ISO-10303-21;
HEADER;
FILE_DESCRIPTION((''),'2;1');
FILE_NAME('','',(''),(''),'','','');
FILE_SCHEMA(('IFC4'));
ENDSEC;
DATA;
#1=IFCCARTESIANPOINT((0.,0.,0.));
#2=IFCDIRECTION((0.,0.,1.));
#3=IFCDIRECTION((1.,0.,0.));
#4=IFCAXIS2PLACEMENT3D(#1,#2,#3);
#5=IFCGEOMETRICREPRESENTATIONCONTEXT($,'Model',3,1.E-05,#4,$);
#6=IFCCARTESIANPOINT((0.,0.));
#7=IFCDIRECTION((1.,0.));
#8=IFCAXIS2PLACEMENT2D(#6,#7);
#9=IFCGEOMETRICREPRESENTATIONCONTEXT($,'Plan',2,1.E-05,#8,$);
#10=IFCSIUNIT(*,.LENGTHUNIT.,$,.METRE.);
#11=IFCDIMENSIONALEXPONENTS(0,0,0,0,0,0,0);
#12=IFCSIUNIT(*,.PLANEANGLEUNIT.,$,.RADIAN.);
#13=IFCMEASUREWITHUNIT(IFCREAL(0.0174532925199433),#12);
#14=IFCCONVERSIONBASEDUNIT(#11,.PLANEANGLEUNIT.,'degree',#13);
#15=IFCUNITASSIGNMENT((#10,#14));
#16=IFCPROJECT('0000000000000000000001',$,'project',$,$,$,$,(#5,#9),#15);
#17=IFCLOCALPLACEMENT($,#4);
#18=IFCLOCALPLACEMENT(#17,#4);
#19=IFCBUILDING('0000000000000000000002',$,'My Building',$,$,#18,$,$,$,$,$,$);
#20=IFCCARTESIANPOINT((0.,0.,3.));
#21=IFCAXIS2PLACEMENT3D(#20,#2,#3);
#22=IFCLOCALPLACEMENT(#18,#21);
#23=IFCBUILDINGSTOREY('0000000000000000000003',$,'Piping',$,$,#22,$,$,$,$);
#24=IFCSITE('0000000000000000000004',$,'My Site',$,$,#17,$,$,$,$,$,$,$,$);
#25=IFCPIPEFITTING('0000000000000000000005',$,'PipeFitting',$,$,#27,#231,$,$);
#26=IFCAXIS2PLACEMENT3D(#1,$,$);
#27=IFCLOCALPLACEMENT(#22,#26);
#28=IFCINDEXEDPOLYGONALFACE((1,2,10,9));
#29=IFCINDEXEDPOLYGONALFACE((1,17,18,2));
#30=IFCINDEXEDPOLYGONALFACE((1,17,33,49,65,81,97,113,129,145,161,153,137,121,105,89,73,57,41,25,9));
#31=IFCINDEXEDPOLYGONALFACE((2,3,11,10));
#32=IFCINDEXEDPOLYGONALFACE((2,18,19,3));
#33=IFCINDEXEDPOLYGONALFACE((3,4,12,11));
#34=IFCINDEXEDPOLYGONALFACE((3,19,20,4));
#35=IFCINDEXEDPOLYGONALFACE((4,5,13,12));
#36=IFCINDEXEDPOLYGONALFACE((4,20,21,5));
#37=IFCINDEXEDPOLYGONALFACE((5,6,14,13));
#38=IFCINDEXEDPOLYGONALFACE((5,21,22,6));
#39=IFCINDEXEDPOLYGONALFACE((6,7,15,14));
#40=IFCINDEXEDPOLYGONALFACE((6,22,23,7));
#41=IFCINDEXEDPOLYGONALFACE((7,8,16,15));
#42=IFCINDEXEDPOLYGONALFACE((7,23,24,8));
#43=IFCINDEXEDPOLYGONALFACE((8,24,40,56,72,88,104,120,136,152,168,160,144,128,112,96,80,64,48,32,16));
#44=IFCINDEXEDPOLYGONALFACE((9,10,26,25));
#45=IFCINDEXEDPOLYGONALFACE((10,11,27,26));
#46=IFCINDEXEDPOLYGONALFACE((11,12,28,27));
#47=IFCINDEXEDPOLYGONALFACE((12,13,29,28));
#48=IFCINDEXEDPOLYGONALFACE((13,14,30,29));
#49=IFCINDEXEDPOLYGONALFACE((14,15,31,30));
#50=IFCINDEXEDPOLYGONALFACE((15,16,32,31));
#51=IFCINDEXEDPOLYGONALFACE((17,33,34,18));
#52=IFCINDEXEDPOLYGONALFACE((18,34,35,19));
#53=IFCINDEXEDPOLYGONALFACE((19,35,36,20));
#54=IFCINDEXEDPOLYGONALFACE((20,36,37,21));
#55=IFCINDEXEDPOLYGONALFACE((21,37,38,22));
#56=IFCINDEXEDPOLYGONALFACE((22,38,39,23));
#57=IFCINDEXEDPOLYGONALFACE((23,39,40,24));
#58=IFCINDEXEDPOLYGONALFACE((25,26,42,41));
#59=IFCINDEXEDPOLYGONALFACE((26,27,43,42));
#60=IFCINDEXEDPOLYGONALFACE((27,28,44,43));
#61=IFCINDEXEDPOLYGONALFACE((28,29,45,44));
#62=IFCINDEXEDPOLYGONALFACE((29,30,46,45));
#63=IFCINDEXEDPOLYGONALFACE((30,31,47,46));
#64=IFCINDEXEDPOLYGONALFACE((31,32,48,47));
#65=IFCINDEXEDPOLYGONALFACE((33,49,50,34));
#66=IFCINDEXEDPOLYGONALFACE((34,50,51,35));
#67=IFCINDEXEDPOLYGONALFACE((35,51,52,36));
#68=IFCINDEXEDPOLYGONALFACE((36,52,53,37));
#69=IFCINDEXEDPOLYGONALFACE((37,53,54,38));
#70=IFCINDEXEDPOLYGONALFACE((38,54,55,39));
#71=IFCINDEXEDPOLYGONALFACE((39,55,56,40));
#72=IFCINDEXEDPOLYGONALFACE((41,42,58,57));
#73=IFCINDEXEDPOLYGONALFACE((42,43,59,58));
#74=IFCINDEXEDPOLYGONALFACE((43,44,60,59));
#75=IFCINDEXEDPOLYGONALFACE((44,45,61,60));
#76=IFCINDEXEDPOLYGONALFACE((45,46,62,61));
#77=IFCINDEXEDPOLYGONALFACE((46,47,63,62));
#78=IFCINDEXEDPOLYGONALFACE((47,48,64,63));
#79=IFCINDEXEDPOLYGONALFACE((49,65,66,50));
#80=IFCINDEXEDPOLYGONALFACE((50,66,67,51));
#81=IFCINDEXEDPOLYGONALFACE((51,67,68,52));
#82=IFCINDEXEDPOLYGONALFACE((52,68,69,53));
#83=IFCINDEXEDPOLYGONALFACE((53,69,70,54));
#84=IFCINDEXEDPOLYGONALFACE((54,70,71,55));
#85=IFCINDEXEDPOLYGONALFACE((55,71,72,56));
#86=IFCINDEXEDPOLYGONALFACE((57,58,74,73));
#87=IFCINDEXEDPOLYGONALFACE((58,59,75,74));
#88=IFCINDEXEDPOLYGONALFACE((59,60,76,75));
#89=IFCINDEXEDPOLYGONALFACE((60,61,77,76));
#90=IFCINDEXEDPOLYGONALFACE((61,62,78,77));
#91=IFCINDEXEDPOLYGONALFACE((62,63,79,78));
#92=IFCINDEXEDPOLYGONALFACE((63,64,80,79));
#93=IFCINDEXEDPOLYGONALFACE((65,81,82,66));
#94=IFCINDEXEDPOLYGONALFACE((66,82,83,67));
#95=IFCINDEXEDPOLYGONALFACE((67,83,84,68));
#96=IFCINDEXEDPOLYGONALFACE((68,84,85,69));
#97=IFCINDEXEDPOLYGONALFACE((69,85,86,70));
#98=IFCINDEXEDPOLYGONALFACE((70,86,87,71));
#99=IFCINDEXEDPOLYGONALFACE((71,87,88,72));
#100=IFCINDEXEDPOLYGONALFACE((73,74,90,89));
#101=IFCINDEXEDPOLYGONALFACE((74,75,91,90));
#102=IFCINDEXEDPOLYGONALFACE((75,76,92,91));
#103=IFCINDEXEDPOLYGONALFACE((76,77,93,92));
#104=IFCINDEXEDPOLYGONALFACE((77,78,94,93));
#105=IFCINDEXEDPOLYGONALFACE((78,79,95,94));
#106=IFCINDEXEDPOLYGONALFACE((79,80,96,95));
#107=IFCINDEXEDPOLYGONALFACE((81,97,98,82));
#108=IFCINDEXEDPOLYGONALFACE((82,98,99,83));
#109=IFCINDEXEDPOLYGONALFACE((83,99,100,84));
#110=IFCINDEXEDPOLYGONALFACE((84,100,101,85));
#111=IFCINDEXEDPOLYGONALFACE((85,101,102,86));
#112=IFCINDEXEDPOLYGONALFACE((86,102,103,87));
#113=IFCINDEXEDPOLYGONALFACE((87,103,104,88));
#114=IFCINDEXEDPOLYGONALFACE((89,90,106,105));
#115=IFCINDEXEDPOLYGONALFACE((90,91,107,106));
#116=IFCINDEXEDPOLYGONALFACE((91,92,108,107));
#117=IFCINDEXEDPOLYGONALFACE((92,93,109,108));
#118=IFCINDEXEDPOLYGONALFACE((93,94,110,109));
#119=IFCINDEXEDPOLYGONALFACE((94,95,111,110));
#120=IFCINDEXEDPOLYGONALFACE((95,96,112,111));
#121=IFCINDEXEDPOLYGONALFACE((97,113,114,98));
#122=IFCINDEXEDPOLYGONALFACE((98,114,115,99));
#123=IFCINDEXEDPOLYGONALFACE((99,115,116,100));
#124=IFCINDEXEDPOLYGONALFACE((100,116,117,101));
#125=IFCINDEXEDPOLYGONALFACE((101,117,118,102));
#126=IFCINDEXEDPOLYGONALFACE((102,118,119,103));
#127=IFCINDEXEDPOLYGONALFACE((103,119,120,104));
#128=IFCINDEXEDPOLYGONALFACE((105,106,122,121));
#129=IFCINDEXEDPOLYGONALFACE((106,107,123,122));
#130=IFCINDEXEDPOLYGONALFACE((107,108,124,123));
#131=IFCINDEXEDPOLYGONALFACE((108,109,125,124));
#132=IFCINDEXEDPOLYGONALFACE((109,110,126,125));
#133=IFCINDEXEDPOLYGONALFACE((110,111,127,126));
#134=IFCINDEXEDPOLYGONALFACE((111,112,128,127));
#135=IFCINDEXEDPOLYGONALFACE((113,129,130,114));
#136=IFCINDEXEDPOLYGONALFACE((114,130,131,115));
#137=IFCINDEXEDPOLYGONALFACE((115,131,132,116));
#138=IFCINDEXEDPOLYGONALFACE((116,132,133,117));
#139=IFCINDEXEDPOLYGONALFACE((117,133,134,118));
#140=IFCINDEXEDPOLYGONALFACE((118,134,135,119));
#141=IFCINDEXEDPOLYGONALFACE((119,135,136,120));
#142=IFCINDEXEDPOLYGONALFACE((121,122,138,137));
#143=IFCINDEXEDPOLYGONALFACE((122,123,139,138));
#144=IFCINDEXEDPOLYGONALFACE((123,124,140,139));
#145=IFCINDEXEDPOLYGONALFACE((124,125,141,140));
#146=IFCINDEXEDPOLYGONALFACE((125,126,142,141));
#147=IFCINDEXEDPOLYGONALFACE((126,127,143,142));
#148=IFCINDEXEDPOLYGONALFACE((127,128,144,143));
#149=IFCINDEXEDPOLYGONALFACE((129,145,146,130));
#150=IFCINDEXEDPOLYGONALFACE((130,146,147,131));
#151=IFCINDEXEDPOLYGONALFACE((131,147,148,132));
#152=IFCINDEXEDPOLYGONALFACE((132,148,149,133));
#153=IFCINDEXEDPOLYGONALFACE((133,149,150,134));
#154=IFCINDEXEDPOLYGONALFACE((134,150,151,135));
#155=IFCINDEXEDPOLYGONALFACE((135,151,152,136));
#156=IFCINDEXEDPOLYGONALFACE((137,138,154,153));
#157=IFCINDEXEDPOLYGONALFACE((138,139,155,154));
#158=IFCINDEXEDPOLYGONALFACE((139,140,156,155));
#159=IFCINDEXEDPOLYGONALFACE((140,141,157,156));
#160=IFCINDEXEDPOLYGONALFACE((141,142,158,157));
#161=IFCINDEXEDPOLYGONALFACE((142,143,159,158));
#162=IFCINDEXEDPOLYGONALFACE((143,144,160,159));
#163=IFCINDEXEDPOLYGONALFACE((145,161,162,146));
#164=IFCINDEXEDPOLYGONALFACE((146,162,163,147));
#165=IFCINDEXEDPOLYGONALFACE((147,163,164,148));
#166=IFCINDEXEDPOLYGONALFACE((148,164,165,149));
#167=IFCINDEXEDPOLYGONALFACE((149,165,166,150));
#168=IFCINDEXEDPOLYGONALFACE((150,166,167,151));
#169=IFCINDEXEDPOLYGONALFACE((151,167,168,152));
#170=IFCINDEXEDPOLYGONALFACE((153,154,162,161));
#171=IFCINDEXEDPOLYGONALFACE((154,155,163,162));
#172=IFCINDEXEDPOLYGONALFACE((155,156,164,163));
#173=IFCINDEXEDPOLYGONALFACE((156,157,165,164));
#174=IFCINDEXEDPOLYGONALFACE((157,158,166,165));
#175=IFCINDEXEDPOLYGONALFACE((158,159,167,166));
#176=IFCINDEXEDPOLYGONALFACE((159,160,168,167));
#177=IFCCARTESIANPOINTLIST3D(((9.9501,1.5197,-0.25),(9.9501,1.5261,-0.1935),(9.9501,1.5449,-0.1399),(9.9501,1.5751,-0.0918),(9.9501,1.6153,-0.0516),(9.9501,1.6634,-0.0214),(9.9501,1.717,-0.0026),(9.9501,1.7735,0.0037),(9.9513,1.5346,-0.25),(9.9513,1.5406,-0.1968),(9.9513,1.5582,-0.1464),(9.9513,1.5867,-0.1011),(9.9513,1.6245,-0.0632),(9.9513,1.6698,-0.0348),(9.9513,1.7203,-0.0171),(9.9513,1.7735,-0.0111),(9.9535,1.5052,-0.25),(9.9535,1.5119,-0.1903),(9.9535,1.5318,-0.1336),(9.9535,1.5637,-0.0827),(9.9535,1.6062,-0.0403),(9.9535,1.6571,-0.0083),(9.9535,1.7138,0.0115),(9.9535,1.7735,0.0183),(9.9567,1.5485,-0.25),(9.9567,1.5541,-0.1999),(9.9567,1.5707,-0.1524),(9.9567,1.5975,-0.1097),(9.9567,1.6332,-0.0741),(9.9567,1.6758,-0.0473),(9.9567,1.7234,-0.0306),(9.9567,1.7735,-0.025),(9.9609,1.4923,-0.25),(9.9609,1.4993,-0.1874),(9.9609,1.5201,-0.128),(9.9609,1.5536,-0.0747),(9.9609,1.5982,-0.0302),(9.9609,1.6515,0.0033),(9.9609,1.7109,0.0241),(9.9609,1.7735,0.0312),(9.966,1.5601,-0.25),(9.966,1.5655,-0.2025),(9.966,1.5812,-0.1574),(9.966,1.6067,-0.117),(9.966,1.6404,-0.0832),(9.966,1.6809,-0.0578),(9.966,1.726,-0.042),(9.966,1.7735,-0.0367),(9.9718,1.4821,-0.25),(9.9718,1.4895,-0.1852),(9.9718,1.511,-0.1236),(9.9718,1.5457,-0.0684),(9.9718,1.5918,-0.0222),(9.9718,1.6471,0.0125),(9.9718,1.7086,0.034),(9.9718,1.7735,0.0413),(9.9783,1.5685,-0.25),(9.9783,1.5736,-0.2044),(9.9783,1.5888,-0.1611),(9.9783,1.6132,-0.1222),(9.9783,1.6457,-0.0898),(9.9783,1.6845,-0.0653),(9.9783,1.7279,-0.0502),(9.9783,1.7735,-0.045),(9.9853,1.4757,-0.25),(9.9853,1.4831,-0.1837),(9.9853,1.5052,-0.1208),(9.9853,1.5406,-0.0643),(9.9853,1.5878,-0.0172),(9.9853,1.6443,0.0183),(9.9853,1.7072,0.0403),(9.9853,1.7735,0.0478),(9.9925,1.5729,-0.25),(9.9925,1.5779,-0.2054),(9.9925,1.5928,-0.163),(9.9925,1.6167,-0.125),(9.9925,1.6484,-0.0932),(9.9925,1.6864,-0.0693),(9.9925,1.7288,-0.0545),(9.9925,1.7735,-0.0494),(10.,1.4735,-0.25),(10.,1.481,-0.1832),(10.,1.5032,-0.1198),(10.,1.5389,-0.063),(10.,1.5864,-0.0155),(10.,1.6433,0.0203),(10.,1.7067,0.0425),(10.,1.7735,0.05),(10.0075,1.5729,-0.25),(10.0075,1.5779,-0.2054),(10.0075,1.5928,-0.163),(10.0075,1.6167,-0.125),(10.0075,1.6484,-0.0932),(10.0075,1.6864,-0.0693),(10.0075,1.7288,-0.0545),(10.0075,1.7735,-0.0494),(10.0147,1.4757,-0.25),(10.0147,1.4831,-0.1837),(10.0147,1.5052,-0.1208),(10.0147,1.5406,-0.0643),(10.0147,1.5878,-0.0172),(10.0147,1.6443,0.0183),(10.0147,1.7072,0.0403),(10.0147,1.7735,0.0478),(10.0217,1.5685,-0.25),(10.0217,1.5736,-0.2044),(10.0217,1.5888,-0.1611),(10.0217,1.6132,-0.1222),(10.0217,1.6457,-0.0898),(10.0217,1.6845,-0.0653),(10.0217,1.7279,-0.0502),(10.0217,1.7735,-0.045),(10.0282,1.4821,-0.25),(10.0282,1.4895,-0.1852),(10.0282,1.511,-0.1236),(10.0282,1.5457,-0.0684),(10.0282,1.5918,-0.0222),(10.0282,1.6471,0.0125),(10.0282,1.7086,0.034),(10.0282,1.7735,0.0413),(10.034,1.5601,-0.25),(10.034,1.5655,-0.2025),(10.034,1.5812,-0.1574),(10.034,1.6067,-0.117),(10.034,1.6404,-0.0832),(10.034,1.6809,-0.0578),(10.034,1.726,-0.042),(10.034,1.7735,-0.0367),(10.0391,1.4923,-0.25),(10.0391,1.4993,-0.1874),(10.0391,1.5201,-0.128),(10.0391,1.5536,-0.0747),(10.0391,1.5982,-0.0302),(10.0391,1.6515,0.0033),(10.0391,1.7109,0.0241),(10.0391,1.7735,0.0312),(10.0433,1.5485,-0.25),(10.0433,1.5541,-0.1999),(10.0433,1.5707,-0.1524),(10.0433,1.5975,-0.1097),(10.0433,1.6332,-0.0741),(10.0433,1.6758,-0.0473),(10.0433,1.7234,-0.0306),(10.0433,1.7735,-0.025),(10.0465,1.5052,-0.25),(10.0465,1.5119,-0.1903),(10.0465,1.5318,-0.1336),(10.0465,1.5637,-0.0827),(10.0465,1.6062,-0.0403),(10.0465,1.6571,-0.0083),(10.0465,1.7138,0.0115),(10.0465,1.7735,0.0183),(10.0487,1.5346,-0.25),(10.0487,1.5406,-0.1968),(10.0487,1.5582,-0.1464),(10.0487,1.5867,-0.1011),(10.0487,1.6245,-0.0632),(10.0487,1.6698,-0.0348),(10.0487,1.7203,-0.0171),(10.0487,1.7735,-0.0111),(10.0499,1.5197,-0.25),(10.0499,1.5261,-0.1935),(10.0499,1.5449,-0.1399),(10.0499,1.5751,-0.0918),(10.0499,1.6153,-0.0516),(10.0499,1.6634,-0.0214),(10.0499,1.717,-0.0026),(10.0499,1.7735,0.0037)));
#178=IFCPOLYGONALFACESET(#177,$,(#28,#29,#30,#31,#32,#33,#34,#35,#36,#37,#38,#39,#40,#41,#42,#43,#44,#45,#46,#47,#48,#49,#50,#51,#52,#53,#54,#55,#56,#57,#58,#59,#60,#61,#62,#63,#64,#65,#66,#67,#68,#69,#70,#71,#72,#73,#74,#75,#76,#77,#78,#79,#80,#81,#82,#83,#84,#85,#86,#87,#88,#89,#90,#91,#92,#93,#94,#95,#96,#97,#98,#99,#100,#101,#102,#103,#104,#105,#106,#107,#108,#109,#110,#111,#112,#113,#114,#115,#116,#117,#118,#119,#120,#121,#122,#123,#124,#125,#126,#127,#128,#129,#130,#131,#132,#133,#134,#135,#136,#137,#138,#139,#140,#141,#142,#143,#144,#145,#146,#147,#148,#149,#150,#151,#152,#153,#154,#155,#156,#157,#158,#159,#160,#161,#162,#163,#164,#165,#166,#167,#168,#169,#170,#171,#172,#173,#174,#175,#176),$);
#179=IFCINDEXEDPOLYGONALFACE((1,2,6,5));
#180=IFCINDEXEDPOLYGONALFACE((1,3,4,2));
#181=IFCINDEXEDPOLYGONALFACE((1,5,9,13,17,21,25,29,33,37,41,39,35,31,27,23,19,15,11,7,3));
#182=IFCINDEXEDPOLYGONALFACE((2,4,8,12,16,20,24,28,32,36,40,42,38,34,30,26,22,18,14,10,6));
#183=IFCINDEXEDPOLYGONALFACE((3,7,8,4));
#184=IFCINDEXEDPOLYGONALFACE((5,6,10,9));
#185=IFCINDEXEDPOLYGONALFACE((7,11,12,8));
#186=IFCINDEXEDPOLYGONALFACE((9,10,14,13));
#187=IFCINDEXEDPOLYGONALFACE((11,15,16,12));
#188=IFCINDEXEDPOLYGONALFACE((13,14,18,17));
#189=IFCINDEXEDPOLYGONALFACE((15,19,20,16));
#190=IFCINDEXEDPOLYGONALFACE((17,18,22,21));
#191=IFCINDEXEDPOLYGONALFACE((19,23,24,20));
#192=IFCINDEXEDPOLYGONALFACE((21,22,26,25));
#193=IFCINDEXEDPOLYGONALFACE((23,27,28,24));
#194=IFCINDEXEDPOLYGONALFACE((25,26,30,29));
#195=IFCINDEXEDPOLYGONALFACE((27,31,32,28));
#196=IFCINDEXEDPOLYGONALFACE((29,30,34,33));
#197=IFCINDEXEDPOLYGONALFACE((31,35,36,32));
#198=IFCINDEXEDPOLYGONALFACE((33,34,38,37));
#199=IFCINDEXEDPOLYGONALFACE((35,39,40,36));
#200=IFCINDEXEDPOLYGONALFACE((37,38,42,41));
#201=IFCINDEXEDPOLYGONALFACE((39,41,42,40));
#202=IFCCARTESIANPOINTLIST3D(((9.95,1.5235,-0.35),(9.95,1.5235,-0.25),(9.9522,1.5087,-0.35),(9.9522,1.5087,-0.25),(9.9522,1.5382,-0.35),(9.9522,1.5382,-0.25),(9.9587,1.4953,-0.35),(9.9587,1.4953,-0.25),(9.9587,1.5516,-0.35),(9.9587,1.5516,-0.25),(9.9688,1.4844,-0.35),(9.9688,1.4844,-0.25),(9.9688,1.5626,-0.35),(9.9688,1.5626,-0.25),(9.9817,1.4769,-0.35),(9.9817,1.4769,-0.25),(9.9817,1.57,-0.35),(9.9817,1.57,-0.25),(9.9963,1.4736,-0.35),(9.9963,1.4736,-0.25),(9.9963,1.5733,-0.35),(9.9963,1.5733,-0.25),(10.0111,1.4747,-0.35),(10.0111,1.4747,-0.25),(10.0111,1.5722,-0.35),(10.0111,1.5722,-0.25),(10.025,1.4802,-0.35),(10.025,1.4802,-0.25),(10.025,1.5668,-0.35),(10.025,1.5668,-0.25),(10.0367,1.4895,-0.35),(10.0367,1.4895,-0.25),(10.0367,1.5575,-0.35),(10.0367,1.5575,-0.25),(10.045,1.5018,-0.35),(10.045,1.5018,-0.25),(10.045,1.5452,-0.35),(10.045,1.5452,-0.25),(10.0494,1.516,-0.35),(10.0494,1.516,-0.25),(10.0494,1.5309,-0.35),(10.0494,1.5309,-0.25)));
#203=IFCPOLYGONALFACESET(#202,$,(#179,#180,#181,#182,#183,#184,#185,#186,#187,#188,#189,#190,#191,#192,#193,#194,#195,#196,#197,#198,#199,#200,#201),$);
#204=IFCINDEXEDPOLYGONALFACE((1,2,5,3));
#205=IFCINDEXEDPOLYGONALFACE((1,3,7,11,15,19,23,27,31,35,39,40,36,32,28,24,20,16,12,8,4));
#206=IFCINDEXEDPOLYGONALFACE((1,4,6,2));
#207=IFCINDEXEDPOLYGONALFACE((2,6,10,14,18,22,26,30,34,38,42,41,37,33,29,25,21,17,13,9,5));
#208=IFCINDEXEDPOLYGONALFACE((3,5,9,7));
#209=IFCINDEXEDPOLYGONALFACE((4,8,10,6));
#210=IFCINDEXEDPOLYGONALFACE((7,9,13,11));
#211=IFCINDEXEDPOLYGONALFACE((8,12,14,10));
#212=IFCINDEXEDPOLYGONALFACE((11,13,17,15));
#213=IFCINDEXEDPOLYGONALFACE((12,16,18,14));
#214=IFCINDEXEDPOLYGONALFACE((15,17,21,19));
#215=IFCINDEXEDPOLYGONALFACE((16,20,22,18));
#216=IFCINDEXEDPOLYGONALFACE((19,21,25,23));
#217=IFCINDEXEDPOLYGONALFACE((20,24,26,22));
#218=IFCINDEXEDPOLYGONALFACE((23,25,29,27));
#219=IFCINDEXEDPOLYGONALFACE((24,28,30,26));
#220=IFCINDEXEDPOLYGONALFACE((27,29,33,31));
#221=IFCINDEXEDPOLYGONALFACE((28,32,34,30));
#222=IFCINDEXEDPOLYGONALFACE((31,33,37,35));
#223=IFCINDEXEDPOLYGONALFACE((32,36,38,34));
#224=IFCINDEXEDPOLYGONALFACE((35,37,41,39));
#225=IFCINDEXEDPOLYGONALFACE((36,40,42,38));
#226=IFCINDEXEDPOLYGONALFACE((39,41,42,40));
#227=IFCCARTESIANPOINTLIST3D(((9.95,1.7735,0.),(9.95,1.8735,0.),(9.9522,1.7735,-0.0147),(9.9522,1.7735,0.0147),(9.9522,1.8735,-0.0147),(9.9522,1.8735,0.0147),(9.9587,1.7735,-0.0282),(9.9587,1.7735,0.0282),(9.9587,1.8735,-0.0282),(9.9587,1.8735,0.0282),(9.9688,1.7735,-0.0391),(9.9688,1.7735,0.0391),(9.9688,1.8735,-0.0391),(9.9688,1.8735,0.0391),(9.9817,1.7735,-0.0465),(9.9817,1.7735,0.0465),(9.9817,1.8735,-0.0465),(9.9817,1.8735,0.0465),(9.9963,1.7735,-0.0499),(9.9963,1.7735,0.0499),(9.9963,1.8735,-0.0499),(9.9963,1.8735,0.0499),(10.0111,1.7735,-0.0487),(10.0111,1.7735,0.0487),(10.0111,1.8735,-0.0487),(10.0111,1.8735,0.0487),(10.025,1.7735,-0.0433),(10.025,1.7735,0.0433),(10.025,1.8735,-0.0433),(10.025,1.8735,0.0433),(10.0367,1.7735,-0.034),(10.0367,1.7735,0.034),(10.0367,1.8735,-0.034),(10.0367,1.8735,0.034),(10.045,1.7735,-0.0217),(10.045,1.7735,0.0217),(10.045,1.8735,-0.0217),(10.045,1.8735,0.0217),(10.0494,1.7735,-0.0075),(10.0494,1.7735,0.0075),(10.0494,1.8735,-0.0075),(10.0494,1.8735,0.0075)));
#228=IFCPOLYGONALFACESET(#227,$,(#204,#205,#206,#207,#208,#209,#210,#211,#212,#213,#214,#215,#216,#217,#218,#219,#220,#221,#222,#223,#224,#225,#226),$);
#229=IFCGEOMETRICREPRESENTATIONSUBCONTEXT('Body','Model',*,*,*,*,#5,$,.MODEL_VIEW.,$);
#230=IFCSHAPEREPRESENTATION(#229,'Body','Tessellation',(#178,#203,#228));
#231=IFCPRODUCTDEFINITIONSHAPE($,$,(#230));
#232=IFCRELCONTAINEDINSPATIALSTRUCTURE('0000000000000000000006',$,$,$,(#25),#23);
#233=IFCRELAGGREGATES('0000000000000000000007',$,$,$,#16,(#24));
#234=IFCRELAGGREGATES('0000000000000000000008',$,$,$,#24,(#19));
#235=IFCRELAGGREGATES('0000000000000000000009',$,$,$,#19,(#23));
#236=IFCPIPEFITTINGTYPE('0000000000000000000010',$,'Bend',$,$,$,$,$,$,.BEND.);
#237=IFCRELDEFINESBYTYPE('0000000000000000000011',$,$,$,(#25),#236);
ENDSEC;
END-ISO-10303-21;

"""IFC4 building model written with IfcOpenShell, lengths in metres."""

from ifc_helpers import new_model, entity, si_unit, converted_unit, frame, origin_with_axes, origin_2d_with_axis, place, context, subcontext, project, spatial, line, indexed_curve, circle, outline, extrude, source, transform, mapped, type_object, type_shapes, element, save


model = new_model("IFC4")

# Units and contexts
model_context = context("Model", 3, precision=1e-05, world=origin_with_axes())
plan_context = context("Plan", 2, precision=1e-05, world=origin_2d_with_axis())
body_context = subcontext(model_context, "Body", "Model", "MODEL_VIEW")
ifc_project = project(units=[si_unit("LENGTHUNIT", "METRE"), converted_unit("PLANEANGLEUNIT", "degree", entity("IfcReal", 0.0174532925199433), si_unit("PLANEANGLEUNIT", "RADIAN"), dimensions=[0, 0, 0, 0, 0, 0, 0])], contexts=[model_context, plan_context])

# Site, building, storey
site_placement = place(None, origin_with_axes())
site = spatial("IfcSite", under=ifc_project, at=site_placement, Name="My Site")
building_placement = place(site_placement, origin_with_axes())
building = spatial("IfcBuilding", under=site, at=building_placement, Name="My Building")
storey_placement = place(building_placement, frame((0.0, 0.0, 3.0), z_axis=(0.0, 0.0, 1.0), x_axis=(1.0, 0.0, 0.0)))
storey = spatial("IfcBuildingStorey", under=building, at=storey_placement, Name="Piping")

# Pipe fitting, opening
pipe_fitting_type = type_object("IfcPipeFittingType", Name="Bend", PredefinedType="BEND")
shared_shape = source(origin_with_axes(), body_context, "Body", "SolidModel", [
    entity("IfcSweptDiskSolid", entity("IfcIndexedPolyCurve", entity("IfcCartesianPointList3D", [[0.0, 0.0, -0.1], [0.0, 0.0732, -0.2768], [0.0, 0.25, -0.35]]), [entity("IfcArcIndex", [1, 2, 3])]), 0.05),
    extrude(circle(Radius=0.05), origin_with_axes(), (0.0, 0.0, -1.0), 0.1),
    extrude(circle(Radius=0.05), frame((0.0, 0.25, -0.35), z_axis=(0.0, 1.0, 0.0), x_axis=(1.0, 0.0, 0.0)), (0.0, 0.0, 1.0), 0.1),
])
type_shapes(pipe_fitting_type, [shared_shape])
pipe_fitting_1_placement = place(storey_placement, frame((10.0, 1.5235, -0.35), z_axis=(0.0, 0.0, -1.0), x_axis=(-1.0, 0.0, 0.0)))
pipe_fitting_1 = element("IfcPipeFitting", 1, at=pipe_fitting_1_placement, inside=storey, type_object=pipe_fitting_type, Name="PipeFitting", context=body_context, shape_type="MappedRepresentation", body=[
    mapped(shared_shape, transform((0.0, 0.0, 0.0), x_axis=(1.0, 0.0, 0.0), y_axis=(0.0, 1.0, 0.0), z_axis=(0.0, 0.0, 1.0), scale=1.0)),
])
opening_1_placement = place(pipe_fitting_1_placement, frame((1.9673, -1.5235, 2.65), z_axis=(0.0, 0.0, -1.0), x_axis=(-1.0, 0.0, 0.0)))
element("IfcOpeningElement", 2, at=opening_1_placement, cuts=pipe_fitting_1, PredefinedType="OPENING", context=body_context, shape_type="SweptSolid", body=[
    extrude(outline(indexed_curve([(0.0, 0.0), (0.5, 0.0), (0.5, 0.5), (0.0, 0.5)], segments=[line(1, 2, 3, 4, 1)])), origin_with_axes(), (0.0, 0.0, 1.0), 0.5),
])

save(model, "model.ifc")
